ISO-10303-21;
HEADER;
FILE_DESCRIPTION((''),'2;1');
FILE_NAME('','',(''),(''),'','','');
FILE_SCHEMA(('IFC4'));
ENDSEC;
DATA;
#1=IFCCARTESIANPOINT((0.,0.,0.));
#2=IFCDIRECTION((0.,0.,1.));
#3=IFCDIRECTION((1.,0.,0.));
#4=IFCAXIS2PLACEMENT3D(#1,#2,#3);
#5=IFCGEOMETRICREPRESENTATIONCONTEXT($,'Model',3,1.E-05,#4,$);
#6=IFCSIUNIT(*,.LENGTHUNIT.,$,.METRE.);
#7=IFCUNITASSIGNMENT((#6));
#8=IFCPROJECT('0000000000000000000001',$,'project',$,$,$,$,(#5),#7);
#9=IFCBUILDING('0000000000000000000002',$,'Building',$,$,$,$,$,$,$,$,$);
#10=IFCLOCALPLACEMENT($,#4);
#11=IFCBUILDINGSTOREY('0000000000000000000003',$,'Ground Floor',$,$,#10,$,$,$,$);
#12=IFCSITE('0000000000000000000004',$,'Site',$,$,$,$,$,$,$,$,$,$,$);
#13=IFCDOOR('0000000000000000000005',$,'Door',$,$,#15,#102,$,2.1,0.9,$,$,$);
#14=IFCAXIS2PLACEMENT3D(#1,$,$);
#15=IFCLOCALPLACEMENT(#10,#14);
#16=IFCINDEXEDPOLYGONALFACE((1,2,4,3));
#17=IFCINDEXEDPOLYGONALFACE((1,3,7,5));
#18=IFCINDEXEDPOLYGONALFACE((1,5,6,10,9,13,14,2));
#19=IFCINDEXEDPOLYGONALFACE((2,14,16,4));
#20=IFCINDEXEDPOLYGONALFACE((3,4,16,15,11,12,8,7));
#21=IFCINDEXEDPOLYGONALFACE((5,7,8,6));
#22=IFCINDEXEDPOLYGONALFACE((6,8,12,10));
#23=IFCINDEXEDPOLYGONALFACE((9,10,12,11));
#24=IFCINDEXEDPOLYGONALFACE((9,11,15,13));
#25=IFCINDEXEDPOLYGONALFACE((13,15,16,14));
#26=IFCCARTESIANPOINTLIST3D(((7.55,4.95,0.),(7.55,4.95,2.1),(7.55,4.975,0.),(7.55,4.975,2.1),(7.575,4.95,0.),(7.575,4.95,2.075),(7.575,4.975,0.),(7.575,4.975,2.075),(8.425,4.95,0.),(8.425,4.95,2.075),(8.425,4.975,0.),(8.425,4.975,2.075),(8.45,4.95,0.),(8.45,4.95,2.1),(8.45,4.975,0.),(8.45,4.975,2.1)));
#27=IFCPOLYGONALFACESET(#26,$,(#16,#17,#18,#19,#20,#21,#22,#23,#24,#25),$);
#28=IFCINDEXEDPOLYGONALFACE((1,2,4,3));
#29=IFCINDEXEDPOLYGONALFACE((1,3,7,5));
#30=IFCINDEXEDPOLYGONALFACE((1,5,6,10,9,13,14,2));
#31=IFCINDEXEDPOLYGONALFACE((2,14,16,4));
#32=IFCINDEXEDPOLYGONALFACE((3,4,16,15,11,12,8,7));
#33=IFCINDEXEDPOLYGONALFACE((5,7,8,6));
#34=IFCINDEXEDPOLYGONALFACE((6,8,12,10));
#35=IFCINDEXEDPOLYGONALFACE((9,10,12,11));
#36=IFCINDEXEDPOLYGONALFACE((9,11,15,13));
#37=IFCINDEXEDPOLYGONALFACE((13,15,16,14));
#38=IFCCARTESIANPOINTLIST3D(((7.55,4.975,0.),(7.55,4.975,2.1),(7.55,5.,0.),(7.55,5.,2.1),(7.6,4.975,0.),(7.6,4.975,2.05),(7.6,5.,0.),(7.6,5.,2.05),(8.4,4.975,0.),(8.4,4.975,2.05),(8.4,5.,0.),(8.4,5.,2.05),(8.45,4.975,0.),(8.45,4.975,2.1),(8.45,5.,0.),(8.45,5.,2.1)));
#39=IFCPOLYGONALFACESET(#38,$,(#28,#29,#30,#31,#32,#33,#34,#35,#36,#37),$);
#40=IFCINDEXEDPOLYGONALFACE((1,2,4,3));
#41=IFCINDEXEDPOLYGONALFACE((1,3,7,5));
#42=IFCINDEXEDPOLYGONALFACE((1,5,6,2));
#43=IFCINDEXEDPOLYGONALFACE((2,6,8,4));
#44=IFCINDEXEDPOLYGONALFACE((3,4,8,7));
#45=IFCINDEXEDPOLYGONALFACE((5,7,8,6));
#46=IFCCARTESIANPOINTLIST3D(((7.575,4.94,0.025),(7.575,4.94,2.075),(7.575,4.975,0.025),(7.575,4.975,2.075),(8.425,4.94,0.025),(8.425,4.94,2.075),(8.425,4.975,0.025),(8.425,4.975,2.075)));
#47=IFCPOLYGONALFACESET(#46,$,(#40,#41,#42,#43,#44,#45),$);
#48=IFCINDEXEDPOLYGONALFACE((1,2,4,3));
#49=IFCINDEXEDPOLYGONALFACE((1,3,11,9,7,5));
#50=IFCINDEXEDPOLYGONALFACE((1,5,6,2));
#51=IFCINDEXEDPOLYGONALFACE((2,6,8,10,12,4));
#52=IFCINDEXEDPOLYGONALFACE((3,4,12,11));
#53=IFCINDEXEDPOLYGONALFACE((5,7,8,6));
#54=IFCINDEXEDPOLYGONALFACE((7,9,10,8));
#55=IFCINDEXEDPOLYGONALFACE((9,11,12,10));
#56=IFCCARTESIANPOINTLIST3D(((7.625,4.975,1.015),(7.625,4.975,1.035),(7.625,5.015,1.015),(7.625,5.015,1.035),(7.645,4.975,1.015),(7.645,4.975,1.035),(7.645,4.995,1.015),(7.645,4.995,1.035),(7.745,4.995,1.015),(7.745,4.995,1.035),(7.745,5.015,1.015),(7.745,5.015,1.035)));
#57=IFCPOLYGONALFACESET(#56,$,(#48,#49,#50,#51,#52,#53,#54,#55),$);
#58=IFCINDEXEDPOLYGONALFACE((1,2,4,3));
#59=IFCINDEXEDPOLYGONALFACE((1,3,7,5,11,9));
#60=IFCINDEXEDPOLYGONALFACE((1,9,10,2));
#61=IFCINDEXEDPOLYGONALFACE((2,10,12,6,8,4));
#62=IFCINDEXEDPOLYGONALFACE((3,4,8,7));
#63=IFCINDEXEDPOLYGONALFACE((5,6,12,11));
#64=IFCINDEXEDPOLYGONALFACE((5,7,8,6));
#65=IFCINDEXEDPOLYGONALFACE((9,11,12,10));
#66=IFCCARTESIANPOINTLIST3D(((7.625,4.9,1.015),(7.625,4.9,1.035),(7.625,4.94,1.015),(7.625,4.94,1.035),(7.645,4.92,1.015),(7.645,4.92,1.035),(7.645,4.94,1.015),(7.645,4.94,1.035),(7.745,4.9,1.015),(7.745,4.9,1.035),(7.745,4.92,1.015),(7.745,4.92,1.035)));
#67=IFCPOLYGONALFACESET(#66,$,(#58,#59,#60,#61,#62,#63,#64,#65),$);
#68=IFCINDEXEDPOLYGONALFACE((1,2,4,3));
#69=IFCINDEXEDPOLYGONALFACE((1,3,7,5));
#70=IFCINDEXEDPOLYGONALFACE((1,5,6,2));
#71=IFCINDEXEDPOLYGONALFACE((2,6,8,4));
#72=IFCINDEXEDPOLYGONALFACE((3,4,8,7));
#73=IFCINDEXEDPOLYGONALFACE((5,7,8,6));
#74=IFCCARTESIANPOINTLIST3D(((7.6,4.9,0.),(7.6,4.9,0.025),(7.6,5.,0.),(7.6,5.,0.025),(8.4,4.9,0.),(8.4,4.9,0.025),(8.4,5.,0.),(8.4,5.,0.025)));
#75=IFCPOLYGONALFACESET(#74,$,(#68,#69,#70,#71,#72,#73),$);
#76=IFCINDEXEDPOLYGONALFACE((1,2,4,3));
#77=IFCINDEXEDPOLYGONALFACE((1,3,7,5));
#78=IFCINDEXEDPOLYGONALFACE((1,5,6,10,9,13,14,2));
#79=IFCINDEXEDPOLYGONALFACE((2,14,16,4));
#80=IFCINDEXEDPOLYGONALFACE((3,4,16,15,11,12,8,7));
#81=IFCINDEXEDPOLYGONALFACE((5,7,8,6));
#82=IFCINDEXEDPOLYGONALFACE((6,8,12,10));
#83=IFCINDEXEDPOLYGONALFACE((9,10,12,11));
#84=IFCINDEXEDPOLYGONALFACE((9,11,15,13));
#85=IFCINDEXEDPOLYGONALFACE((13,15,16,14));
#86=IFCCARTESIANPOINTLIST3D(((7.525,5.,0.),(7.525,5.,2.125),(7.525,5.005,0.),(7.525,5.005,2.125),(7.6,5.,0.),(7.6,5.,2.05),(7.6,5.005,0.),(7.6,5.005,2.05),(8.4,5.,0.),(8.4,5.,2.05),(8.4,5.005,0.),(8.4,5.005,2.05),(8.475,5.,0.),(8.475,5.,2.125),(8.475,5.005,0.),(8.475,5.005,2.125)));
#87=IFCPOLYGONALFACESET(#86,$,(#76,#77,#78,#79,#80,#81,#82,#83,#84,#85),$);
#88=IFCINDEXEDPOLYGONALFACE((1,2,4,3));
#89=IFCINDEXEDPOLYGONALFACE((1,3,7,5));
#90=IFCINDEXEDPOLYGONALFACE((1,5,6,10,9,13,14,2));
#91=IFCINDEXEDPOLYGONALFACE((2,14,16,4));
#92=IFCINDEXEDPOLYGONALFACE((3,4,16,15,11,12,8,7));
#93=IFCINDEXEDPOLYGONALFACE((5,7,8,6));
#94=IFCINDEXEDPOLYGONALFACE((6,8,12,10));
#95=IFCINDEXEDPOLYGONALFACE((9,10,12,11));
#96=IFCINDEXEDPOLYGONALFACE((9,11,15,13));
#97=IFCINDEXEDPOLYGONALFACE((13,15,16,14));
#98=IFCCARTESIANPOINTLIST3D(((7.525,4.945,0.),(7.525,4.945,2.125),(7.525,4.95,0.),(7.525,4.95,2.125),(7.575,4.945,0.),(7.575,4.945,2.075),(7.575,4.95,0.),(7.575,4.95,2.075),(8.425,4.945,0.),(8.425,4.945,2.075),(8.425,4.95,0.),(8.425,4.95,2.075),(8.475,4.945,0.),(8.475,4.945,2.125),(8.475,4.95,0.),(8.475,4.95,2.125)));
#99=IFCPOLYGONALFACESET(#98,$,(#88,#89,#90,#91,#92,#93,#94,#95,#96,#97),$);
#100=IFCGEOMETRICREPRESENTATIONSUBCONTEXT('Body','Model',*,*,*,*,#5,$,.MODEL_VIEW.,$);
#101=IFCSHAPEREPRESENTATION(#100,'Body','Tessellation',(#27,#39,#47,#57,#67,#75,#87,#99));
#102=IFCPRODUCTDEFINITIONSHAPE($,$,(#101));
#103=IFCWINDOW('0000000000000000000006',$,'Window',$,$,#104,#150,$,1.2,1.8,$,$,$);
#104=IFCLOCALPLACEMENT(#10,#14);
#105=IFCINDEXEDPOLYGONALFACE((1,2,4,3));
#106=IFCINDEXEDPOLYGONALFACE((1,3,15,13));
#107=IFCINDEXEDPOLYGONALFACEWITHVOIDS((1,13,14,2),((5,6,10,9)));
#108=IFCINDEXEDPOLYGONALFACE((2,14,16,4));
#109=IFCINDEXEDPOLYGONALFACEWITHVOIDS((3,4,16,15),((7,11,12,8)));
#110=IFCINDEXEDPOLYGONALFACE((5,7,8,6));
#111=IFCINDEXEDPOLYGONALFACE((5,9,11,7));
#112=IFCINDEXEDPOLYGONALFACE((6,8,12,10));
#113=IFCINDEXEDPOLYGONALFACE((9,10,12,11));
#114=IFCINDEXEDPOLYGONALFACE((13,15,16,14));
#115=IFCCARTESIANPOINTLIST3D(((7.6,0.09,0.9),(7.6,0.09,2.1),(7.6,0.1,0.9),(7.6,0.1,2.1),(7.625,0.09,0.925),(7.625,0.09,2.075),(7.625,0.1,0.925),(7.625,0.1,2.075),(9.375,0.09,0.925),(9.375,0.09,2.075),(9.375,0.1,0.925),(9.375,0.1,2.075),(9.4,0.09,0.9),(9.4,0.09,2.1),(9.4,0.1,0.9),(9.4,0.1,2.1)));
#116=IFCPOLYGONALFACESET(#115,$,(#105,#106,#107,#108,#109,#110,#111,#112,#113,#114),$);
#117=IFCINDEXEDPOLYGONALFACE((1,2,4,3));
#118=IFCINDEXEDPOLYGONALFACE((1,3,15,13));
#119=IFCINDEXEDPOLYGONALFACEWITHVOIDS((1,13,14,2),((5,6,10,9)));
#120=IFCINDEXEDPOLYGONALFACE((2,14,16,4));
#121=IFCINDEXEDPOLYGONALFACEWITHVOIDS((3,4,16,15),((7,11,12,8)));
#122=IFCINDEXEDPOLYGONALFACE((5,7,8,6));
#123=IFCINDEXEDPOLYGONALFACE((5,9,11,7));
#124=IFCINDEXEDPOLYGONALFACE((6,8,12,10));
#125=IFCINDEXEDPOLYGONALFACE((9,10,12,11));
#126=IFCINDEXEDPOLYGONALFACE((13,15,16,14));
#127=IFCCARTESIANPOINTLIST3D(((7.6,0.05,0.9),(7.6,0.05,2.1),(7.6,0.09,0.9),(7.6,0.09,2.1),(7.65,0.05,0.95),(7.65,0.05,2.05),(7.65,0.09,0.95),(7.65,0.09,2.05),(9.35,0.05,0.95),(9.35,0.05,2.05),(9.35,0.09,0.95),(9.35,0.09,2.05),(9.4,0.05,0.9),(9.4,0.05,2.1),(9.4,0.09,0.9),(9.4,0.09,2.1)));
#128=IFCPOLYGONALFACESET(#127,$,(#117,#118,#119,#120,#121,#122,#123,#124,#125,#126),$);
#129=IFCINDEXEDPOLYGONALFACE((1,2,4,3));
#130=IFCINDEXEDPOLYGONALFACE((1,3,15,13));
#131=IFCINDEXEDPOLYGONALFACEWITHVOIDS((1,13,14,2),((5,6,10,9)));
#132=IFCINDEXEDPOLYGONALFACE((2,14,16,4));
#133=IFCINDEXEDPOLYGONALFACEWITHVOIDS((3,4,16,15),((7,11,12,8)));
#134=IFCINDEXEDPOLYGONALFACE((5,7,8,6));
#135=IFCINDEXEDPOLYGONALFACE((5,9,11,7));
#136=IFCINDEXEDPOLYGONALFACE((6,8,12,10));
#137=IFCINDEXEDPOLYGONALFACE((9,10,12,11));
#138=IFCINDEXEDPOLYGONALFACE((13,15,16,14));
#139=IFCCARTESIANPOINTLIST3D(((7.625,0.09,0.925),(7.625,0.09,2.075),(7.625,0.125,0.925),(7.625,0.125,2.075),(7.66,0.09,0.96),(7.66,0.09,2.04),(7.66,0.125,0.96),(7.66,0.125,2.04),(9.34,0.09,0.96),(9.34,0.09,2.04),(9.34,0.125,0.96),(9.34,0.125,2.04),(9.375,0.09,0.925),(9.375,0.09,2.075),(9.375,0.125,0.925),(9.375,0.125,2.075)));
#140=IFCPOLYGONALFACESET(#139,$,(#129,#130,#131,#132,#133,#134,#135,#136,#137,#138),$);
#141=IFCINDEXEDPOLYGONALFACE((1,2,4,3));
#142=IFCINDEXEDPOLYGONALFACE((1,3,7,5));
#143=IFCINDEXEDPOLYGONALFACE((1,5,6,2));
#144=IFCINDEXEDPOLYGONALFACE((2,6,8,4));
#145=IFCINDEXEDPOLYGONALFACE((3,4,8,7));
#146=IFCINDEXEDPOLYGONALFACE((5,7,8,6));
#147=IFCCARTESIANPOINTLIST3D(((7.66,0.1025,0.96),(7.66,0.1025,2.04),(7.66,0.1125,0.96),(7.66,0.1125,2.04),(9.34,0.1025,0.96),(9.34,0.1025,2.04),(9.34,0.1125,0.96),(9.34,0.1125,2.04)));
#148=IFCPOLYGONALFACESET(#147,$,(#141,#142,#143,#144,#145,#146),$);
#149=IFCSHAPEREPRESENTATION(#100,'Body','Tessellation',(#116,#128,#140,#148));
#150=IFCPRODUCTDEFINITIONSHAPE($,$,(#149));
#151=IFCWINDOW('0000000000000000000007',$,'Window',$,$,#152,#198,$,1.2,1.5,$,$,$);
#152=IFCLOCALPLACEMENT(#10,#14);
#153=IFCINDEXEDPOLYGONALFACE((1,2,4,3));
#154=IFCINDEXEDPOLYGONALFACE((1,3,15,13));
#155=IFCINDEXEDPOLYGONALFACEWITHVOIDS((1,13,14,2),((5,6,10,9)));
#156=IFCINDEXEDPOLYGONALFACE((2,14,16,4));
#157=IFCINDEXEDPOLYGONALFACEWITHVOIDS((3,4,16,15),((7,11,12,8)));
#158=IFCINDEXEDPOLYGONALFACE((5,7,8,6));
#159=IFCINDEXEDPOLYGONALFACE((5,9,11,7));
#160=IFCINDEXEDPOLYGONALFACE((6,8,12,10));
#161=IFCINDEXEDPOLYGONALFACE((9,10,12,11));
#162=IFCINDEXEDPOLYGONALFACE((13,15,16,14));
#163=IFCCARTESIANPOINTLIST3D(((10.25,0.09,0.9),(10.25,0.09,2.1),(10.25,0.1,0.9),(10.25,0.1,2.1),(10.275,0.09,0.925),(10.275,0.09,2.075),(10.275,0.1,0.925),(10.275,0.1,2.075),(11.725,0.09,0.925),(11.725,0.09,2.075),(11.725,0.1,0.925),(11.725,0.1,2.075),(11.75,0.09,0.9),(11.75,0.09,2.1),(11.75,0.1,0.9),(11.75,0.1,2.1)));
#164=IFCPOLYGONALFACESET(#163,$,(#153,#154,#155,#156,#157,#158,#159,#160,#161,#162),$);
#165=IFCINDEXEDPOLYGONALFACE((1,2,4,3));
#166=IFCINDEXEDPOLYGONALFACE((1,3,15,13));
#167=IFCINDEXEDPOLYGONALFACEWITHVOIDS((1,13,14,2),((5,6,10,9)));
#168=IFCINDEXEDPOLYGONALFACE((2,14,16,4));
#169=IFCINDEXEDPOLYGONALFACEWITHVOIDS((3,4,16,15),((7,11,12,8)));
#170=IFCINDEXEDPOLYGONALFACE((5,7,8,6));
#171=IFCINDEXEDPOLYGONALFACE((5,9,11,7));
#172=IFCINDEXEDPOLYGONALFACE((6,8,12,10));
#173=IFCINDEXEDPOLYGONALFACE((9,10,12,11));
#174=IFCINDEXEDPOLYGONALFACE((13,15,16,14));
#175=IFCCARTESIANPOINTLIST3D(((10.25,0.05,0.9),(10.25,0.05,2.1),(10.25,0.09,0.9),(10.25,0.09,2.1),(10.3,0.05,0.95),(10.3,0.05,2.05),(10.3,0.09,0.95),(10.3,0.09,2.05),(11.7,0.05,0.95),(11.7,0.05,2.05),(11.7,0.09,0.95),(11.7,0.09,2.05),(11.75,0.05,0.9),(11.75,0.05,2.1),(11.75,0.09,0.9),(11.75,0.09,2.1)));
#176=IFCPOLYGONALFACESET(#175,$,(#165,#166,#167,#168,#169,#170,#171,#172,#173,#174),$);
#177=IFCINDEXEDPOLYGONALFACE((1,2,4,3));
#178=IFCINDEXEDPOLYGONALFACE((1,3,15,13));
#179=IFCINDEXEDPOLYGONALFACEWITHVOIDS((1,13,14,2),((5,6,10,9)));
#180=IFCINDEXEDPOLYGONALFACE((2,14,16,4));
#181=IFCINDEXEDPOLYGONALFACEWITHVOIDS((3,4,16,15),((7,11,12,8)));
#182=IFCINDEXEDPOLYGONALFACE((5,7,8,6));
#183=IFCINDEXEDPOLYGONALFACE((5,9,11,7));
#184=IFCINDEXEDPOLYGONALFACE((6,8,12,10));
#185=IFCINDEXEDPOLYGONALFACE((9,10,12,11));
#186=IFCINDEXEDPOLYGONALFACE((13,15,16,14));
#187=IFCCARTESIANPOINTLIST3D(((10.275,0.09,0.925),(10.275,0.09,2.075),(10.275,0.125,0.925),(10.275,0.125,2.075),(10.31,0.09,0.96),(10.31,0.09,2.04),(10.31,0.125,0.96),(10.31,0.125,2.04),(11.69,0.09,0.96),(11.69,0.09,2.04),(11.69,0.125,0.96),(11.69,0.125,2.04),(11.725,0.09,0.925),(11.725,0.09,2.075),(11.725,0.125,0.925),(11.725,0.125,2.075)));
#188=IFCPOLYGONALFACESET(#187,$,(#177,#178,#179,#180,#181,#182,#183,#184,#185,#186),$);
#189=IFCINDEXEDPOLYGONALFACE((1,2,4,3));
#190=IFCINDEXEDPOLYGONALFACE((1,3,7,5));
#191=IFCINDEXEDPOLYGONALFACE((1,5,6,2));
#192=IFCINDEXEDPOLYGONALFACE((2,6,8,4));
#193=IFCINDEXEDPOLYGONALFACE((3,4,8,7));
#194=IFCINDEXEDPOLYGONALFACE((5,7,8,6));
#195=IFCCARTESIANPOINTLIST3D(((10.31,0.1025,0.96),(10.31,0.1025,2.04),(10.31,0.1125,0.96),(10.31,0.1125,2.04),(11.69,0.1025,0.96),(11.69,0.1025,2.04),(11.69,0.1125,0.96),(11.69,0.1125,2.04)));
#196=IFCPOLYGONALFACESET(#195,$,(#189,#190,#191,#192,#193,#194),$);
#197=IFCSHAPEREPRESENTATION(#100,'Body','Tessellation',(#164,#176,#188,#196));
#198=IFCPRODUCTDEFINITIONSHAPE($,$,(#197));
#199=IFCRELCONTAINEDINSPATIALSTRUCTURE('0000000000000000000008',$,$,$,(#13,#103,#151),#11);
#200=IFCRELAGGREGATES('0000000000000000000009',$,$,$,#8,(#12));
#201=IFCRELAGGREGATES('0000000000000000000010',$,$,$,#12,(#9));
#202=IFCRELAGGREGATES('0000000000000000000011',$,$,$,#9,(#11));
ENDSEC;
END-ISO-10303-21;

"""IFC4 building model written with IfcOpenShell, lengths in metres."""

from ifc_helpers import new_model, si_unit, frame, origin_with_axes, place, context, subcontext, project, spatial, line, indexed_curve, outline, extrude, element, save


model = new_model("IFC4")

# Units and contexts
model_context = context("Model", 3, precision=1e-05, world=origin_with_axes())
body_context = subcontext(model_context, "Body", "Model", "MODEL_VIEW")
ifc_project = project(units=[si_unit("LENGTHUNIT", "METRE")], contexts=[model_context])

# Site, building, storey
site = spatial("IfcSite", under=ifc_project, Name="Site")
building = spatial("IfcBuilding", under=site, Name="Building")
storey_placement = place(None, origin_with_axes())
storey = spatial("IfcBuildingStorey", under=building, at=storey_placement, Name="Ground Floor")

# Door
door_1_placement = place(storey_placement, frame((8.45, 5.0, 0.0), z_axis=(0.0, 0.0, 1.0), x_axis=(-1.0, 0.0, 0.0)))
element("IfcDoor", 1, at=door_1_placement, inside=storey, Name="Door", OverallHeight=2.1, OverallWidth=0.9, context=body_context, shape_type="SweptSolid", body=[
    extrude(outline(indexed_curve([(0.0, 0.0), (0.0, 2.1), (0.9, 2.1), (0.9, 0.0), (0.875, 0.0), (0.875, 2.075), (0.025, 2.075), (0.025, 0.0)], segments=[line(1, 2, 3, 4, 5, 6, 7, 8, 1)])), frame((0.0, 0.025, 0.0), z_axis=(0.0, -1.0, 0.0), x_axis=(1.0, 0.0, 0.0)), (0.0, 0.0, -1.0), 0.025),
    extrude(outline(indexed_curve([(0.0, 0.0), (0.0, 2.1), (0.9, 2.1), (0.9, 0.0), (0.85, 0.0), (0.85, 2.05), (0.05, 2.05), (0.05, 0.0)], segments=[line(1, 2, 3, 4, 5, 6, 7, 8, 1)])), frame((0.0, 0.0, 0.0), z_axis=(0.0, -1.0, 0.0), x_axis=(1.0, 0.0, 0.0)), (0.0, 0.0, -1.0), 0.025),
    extrude(outline(indexed_curve([(0.0, 0.0), (0.85, 0.0), (0.85, 0.035), (0.0, 0.035)], segments=[line(1, 2, 3, 4, 1)])), frame((0.025, 0.025, 0.025), z_axis=(0.0, 0.0, 1.0), x_axis=(1.0, 0.0, 0.0)), (0.0, 0.0, 1.0), 2.05),
    extrude(outline(indexed_curve([(0.0, 0.0), (0.0, -0.04), (-0.12, -0.04), (-0.12, -0.02), (-0.02, -0.02), (-0.02, 0.0)], segments=[line(1, 2, 3, 4, 5, 6, 1)])), frame((0.825, 0.025, 1.015), z_axis=(0.0, 0.0, 1.0), x_axis=(1.0, 0.0, 0.0)), (0.0, 0.0, 1.0), 0.02),
    extrude(outline(indexed_curve([(0.0, 0.0), (0.0, 0.04), (-0.12, 0.04), (-0.12, 0.02), (-0.02, 0.02), (-0.02, 0.0)], segments=[line(1, 2, 3, 4, 5, 6, 1)])), frame((0.825, 0.06, 1.015), z_axis=(0.0, 0.0, 1.0), x_axis=(1.0, 0.0, 0.0)), (0.0, 0.0, 1.0), 0.02),
    extrude(outline(indexed_curve([(0.0, 0.0), (0.8, 0.0), (0.8, 0.1), (0.0, 0.1)], segments=[line(1, 2, 3, 4, 1)])), frame((0.05, 0.0, 0.0), z_axis=(0.0, 0.0, 1.0), x_axis=(1.0, 0.0, 0.0)), (0.0, 0.0, 1.0), 0.025),
    extrude(outline(indexed_curve([(0.0, 0.0), (0.0, 2.125), (0.95, 2.125), (0.95, 0.0), (0.875, 0.0), (0.875, 2.05), (0.075, 2.05), (0.075, 0.0)], segments=[line(1, 2, 3, 4, 5, 6, 7, 8, 1)])), frame((-0.025, -0.005, 0.0), z_axis=(0.0, -1.0, 0.0), x_axis=(1.0, 0.0, 0.0)), (0.0, 0.0, -1.0), 0.005),
    extrude(outline(indexed_curve([(0.0, 0.0), (0.0, 2.125), (0.95, 2.125), (0.95, 0.0), (0.9, 0.0), (0.9, 2.075), (0.05, 2.075), (0.05, 0.0)], segments=[line(1, 2, 3, 4, 5, 6, 7, 8, 1)])), frame((-0.025, 0.05, 0.0), z_axis=(0.0, -1.0, 0.0), x_axis=(1.0, 0.0, 0.0)), (0.0, 0.0, -1.0), 0.005),
])

# Windows
window_placement = place(storey_placement, frame((7.6, 0.0, 0.9), z_axis=(0.0, 0.0, 1.0), x_axis=(1.0, 0.0, 0.0)))
element("IfcWindow", 2, at=window_placement, inside=storey, Name="Window", OverallHeight=1.2, OverallWidth=1.8, context=body_context, shape_type="SweptSolid", body=[
    extrude(outline(indexed_curve([(0.0, 0.0), (1.8, 0.0), (1.8, 1.2), (0.0, 1.2)], segments=[line(1, 2, 3, 4, 1)]), holes=[indexed_curve([(0.025, 0.025), (1.775, 0.025), (1.775, 1.175), (0.025, 1.175)], segments=[line(1, 2, 3, 4, 1)])]), frame((0.0, 0.09, 0.0), z_axis=(0.0, -1.0, 0.0), x_axis=(1.0, 0.0, 0.0)), (0.0, 0.0, -1.0), 0.01),
    extrude(outline(indexed_curve([(0.0, 0.0), (1.8, 0.0), (1.8, 1.2), (0.0, 1.2)], segments=[line(1, 2, 3, 4, 1)]), holes=[indexed_curve([(0.05, 0.05), (1.75, 0.05), (1.75, 1.15), (0.05, 1.15)], segments=[line(1, 2, 3, 4, 1)])]), frame((0.0, 0.05, 0.0), z_axis=(0.0, -1.0, 0.0), x_axis=(1.0, 0.0, 0.0)), (0.0, 0.0, -1.0), 0.04),
    extrude(outline(indexed_curve([(0.0, 0.0), (1.75, 0.0), (1.75, 1.15), (0.0, 1.15)], segments=[line(1, 2, 3, 4, 1)]), holes=[indexed_curve([(0.035, 0.035), (1.715, 0.035), (1.715, 1.115), (0.035, 1.115)], segments=[line(1, 2, 3, 4, 1)])]), frame((0.025, 0.09, 0.025), z_axis=(0.0, -1.0, 0.0), x_axis=(1.0, 0.0, 0.0)), (0.0, 0.0, -1.0), 0.035),
    extrude(outline(indexed_curve([(0.035, 0.035), (1.715, 0.035), (1.715, 1.115), (0.035, 1.115)], segments=[line(1, 2, 3, 4, 1)])), frame((0.025, 0.1025, 0.025), z_axis=(0.0, -1.0, 0.0), x_axis=(1.0, 0.0, 0.0)), (0.0, 0.0, -1.0), 0.01),
])
for number, where, z_axis, x_axis, name in (
    (3, (10.25, 0.0, 0.9), (0.0, 0.0, 1.0), (1.0, 0.0, 0.0), "Window"),
):
    element("IfcWindow", number, at=place(storey_placement, frame(where, z_axis=z_axis, x_axis=x_axis)), inside=storey, Name=name, OverallHeight=1.2, OverallWidth=1.5, context=body_context, shape_type="SweptSolid", body=[
        extrude(outline(indexed_curve([(0.0, 0.0), (1.5, 0.0), (1.5, 1.2), (0.0, 1.2)], segments=[line(1, 2, 3, 4, 1)]), holes=[indexed_curve([(0.025, 0.025), (1.475, 0.025), (1.475, 1.175), (0.025, 1.175)], segments=[line(1, 2, 3, 4, 1)])]), frame((0.0, 0.09, 0.0), z_axis=(0.0, -1.0, 0.0), x_axis=(1.0, 0.0, 0.0)), (0.0, 0.0, -1.0), 0.01),
        extrude(outline(indexed_curve([(0.0, 0.0), (1.5, 0.0), (1.5, 1.2), (0.0, 1.2)], segments=[line(1, 2, 3, 4, 1)]), holes=[indexed_curve([(0.05, 0.05), (1.45, 0.05), (1.45, 1.15), (0.05, 1.15)], segments=[line(1, 2, 3, 4, 1)])]), frame((0.0, 0.05, 0.0), z_axis=(0.0, -1.0, 0.0), x_axis=(1.0, 0.0, 0.0)), (0.0, 0.0, -1.0), 0.04),
        extrude(outline(indexed_curve([(0.0, 0.0), (1.45, 0.0), (1.45, 1.15), (0.0, 1.15)], segments=[line(1, 2, 3, 4, 1)]), holes=[indexed_curve([(0.035, 0.035), (1.415, 0.035), (1.415, 1.115), (0.035, 1.115)], segments=[line(1, 2, 3, 4, 1)])]), frame((0.025, 0.09, 0.025), z_axis=(0.0, -1.0, 0.0), x_axis=(1.0, 0.0, 0.0)), (0.0, 0.0, -1.0), 0.035),
        extrude(outline(indexed_curve([(0.035, 0.035), (1.415, 0.035), (1.415, 1.115), (0.035, 1.115)], segments=[line(1, 2, 3, 4, 1)])), frame((0.025, 0.1025, 0.025), z_axis=(0.0, -1.0, 0.0), x_axis=(1.0, 0.0, 0.0)), (0.0, 0.0, -1.0), 0.01),
    ])

save(model, "model.ifc")
